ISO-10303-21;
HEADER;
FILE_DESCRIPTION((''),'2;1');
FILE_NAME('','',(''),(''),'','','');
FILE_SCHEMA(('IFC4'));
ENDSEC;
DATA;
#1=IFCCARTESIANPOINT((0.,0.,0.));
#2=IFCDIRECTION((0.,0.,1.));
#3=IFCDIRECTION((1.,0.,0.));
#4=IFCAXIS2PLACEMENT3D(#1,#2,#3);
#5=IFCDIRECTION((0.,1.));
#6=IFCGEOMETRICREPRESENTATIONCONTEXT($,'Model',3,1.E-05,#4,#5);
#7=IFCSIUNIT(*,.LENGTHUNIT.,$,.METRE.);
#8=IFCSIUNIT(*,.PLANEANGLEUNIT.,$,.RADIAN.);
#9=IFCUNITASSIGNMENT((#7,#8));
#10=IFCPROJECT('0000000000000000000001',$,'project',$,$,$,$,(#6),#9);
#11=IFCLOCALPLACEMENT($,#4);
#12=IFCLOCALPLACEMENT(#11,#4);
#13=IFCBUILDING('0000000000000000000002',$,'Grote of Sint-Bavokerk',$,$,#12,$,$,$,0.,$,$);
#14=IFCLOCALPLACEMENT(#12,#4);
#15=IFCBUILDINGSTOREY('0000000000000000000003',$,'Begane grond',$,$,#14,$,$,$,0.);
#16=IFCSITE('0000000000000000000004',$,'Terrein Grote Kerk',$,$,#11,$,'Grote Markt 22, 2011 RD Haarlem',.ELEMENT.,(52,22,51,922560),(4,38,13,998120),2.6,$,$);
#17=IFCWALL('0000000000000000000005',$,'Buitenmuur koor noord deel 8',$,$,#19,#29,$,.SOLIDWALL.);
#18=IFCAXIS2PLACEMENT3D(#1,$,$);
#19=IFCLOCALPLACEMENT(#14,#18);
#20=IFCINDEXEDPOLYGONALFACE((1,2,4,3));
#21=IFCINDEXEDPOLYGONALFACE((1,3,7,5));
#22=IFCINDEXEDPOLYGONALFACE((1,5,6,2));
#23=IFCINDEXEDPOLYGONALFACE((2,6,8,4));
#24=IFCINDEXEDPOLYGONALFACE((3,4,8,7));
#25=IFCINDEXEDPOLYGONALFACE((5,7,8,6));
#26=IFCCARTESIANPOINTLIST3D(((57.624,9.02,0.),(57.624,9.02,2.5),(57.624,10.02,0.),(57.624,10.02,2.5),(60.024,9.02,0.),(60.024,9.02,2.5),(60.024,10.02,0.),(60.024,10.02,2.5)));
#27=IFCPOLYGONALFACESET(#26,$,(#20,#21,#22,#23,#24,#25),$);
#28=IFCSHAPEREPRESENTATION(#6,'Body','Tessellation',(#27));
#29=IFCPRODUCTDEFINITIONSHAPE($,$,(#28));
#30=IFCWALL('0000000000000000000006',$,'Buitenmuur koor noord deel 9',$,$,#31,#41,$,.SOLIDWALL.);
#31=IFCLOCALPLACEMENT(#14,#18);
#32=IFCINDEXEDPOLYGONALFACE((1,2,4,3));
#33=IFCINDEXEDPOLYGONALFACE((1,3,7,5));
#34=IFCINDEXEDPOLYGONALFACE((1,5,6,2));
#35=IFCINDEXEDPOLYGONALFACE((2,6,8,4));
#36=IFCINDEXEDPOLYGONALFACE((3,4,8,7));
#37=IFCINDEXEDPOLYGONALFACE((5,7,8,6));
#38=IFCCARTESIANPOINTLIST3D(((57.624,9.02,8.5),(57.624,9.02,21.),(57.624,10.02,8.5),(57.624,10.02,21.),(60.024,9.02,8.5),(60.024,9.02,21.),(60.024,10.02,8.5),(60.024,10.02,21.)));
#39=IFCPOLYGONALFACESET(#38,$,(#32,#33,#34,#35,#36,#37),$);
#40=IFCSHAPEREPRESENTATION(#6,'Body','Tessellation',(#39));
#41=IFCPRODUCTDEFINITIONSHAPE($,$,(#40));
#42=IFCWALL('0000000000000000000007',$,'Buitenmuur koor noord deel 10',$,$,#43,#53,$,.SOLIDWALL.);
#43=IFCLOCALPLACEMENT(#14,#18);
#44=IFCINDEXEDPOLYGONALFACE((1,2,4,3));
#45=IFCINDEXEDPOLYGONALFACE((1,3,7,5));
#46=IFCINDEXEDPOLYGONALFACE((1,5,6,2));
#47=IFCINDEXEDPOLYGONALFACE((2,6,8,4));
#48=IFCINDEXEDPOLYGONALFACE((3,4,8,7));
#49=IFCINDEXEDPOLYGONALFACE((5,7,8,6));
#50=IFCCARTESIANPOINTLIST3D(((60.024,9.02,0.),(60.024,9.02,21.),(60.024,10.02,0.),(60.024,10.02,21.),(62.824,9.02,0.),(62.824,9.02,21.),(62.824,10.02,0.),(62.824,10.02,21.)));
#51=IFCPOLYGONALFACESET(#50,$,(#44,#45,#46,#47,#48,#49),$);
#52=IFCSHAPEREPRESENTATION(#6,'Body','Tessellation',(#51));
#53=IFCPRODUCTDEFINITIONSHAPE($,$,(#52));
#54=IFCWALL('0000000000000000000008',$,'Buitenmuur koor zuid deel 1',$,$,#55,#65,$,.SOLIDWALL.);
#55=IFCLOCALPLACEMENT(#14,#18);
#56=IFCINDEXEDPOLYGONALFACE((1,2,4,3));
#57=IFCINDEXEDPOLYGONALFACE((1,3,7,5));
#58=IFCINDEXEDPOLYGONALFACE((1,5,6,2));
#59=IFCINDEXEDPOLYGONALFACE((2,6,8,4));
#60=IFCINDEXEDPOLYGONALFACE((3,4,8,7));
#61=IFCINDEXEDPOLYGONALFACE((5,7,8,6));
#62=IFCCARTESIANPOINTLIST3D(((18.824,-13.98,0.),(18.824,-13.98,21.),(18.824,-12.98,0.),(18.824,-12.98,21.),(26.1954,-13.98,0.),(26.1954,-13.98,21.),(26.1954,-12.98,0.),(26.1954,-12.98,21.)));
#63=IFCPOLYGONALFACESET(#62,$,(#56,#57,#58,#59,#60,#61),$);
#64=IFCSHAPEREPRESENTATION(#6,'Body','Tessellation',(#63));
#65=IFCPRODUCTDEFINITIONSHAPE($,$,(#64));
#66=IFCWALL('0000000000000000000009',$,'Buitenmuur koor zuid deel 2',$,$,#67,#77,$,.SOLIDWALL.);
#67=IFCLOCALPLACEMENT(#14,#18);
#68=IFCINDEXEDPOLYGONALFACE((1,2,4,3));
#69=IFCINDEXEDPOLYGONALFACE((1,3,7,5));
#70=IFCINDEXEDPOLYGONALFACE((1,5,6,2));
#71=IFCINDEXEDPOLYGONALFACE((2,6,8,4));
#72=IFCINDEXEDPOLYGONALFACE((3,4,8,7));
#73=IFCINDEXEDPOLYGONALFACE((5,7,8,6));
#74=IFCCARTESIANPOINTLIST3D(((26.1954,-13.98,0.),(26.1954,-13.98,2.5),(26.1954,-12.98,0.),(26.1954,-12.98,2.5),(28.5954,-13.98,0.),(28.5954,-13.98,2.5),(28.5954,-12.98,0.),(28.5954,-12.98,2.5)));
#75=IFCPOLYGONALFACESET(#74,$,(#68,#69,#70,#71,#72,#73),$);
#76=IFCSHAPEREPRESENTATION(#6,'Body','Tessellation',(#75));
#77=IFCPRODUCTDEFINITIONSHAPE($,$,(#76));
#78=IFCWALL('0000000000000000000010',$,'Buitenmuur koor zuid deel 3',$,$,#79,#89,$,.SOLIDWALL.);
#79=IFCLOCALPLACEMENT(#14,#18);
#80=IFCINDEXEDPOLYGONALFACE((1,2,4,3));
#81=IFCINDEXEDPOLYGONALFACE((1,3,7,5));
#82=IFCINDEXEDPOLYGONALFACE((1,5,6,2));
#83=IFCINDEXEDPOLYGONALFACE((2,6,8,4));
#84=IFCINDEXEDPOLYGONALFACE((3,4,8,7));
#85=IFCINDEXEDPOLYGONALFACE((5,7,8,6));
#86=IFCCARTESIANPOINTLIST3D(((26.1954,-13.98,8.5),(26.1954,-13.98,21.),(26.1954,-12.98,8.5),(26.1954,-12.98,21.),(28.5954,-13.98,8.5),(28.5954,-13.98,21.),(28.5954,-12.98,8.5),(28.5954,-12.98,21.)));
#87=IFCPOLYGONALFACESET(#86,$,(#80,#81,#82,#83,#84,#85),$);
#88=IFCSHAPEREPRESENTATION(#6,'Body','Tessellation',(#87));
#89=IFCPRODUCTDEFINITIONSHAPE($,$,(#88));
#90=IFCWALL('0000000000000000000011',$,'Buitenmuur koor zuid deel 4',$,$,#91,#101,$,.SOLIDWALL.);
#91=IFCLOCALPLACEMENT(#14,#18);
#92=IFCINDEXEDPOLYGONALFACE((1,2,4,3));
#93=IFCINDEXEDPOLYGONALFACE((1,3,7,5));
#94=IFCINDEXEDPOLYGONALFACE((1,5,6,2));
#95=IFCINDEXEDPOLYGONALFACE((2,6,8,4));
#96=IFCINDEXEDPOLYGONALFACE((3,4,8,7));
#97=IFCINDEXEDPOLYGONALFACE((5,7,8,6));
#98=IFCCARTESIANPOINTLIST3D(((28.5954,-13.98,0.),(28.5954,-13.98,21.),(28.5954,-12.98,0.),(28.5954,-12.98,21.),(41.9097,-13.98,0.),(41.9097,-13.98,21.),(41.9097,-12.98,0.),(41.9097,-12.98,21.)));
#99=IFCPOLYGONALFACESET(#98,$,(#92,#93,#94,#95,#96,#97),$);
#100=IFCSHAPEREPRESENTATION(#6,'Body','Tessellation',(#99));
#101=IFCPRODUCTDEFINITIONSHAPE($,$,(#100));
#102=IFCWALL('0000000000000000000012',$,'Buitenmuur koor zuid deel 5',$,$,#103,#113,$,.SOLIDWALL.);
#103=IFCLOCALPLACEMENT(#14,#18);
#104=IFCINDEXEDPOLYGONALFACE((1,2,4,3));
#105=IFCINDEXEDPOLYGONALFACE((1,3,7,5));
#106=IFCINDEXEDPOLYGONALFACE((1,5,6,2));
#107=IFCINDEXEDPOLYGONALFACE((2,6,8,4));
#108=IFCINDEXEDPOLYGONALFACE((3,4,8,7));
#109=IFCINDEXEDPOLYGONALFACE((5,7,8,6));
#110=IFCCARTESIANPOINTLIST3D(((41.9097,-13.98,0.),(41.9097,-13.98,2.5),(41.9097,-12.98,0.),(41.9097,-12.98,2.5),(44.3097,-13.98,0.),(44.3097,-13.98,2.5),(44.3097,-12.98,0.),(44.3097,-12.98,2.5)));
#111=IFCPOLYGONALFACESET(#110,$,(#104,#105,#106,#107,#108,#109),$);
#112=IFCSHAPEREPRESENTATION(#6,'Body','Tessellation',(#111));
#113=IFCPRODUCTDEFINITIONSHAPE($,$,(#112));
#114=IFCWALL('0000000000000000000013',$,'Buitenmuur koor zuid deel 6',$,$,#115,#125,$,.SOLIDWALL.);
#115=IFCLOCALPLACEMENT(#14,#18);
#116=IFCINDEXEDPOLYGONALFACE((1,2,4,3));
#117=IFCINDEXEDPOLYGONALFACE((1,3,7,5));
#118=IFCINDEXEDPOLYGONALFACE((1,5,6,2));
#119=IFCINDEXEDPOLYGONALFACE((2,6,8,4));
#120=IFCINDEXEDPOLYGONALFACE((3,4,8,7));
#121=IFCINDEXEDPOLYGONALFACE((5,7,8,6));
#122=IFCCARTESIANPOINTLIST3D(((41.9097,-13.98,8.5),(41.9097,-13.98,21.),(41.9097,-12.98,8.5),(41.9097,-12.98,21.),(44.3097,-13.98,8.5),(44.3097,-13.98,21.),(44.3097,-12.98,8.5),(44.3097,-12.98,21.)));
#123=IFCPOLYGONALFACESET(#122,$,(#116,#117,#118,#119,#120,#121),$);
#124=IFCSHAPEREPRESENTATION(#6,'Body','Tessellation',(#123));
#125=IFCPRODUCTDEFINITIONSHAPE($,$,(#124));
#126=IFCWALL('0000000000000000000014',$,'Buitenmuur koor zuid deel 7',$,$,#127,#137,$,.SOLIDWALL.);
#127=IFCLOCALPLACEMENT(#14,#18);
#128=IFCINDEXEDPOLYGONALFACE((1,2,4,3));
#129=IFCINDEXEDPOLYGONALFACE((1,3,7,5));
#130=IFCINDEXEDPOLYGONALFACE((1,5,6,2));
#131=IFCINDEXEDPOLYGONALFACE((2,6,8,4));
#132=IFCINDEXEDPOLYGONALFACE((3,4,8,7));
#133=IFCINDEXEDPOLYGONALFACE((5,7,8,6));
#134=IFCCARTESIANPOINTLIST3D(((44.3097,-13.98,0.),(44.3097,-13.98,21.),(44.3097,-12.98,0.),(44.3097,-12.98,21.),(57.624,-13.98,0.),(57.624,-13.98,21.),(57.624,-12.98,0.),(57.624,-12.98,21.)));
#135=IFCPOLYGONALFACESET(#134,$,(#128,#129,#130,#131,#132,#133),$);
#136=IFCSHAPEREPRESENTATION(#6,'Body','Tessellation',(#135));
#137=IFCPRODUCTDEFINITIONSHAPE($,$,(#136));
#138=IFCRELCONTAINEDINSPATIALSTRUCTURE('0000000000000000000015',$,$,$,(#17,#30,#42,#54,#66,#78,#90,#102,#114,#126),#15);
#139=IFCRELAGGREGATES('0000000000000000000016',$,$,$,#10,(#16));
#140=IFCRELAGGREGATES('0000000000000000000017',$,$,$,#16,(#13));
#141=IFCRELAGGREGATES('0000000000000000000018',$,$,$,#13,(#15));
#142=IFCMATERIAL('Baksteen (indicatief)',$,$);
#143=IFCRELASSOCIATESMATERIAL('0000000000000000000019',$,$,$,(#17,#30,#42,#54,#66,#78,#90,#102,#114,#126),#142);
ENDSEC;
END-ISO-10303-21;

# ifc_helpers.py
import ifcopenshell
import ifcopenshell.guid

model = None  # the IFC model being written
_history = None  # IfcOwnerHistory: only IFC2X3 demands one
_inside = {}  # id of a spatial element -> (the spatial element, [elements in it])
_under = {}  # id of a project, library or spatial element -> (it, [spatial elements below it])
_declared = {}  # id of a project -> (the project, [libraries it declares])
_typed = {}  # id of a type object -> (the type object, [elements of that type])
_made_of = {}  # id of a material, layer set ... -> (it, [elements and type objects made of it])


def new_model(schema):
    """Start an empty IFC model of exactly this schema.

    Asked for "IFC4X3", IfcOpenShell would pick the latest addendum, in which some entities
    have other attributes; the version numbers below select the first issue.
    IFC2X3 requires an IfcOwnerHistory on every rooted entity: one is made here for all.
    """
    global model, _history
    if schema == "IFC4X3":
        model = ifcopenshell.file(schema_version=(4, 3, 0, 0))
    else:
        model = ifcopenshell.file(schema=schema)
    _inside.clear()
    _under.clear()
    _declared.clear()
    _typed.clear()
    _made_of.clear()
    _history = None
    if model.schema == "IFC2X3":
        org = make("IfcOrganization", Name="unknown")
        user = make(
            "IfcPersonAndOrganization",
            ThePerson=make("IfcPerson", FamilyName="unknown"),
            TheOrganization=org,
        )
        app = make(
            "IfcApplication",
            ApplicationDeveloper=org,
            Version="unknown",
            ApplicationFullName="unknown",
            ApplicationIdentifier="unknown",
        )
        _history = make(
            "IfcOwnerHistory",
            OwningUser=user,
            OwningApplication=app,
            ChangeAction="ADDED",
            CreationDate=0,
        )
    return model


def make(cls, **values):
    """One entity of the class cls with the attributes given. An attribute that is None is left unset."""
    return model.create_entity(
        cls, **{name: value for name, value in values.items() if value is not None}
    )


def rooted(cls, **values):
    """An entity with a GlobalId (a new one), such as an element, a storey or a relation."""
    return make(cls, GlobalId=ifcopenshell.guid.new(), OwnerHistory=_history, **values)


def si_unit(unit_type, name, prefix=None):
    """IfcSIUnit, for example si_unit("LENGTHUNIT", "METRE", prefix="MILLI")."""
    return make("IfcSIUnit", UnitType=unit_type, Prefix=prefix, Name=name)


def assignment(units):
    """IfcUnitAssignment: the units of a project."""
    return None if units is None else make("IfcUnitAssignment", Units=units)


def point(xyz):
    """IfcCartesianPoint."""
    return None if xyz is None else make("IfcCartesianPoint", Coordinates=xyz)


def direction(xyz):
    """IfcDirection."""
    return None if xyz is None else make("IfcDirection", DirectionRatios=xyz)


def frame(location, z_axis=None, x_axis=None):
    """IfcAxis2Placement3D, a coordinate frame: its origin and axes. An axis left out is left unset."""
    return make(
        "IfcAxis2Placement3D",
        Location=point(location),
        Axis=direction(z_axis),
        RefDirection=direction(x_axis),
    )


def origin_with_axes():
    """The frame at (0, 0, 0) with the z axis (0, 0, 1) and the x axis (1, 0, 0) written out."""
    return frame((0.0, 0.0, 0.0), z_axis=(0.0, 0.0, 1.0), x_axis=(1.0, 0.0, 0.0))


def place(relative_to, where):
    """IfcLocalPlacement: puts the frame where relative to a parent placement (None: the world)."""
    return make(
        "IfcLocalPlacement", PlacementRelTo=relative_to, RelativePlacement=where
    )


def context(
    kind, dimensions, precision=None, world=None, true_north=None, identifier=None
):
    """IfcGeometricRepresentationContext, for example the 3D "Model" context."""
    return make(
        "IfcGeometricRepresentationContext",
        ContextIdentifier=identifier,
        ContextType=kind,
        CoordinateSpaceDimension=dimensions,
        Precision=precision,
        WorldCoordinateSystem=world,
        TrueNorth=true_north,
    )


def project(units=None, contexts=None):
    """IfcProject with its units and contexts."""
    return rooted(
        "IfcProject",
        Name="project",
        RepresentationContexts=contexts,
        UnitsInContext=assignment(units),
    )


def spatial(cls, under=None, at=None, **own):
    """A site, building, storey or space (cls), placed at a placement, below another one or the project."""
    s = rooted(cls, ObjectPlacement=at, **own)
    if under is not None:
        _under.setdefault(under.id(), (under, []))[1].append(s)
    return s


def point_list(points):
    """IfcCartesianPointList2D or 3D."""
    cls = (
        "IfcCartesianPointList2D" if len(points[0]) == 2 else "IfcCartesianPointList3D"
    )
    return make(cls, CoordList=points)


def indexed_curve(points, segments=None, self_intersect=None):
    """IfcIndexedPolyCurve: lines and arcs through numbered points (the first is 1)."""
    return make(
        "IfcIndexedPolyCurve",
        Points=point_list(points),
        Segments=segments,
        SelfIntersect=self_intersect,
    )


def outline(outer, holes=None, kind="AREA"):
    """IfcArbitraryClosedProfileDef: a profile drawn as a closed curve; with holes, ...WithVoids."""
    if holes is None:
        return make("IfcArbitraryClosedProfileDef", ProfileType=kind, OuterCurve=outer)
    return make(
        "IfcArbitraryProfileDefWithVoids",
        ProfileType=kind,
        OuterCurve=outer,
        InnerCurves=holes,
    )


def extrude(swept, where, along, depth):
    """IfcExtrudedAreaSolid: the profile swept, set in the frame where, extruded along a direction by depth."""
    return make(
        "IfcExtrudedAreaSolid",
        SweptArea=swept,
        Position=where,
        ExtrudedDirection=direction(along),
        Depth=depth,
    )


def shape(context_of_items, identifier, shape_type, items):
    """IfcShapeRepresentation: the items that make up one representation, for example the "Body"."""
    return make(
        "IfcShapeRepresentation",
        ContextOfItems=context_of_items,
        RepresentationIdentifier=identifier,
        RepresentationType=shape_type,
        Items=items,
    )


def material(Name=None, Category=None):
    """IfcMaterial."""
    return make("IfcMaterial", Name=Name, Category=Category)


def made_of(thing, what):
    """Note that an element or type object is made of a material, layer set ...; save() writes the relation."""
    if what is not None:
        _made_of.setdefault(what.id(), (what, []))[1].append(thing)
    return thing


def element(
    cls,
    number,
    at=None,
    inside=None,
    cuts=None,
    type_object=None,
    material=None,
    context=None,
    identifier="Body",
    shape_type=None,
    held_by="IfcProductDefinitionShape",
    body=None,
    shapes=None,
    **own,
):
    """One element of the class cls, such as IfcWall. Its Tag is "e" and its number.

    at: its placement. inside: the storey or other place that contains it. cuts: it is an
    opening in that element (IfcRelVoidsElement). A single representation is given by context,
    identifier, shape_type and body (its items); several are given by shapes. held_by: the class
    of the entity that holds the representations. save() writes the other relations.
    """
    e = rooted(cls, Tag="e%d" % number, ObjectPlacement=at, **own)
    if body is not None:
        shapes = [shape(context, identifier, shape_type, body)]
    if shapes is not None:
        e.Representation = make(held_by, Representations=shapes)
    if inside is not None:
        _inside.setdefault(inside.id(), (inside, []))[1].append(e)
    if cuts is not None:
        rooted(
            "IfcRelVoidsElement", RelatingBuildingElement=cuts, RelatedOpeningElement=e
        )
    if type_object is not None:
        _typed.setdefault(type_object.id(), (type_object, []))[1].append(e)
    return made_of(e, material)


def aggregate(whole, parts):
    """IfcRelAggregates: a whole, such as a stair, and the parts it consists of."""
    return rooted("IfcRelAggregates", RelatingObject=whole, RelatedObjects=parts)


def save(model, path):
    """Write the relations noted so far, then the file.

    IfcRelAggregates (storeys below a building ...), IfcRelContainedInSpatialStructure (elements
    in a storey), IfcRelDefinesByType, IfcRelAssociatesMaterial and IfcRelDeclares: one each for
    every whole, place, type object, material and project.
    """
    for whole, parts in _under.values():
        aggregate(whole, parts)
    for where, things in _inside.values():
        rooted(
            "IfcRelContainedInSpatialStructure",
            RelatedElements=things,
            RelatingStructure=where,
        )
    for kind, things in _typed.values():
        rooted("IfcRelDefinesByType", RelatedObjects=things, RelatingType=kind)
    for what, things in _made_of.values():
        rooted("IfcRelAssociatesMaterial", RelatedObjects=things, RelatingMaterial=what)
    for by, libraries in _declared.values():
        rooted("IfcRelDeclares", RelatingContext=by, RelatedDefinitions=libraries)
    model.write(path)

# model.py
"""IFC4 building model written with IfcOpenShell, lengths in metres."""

from ifc_helpers import new_model, si_unit, direction, frame, origin_with_axes, place, context, project, spatial, indexed_curve, outline, extrude, material, element, save


model = new_model("IFC4")

# Units and contexts
model_context = context("Model", 3, precision=1e-05, world=origin_with_axes(), true_north=direction((0.0, 1.0)))
ifc_project = project(units=[si_unit("LENGTHUNIT", "METRE"), si_unit("PLANEANGLEUNIT", "RADIAN")], contexts=[model_context])

# Site, building, storey
site_placement = place(None, origin_with_axes())
site = spatial("IfcSite", under=ifc_project, at=site_placement, Name="Terrein Grote Kerk", LongName="Grote Markt 22, 2011 RD Haarlem", CompositionType="ELEMENT", RefLatitude=(52, 22, 51, 922560), RefLongitude=(4, 38, 13, 998120), RefElevation=2.6)
building_placement = place(site_placement, origin_with_axes())
building = spatial("IfcBuilding", under=site, at=building_placement, Name="Grote of Sint-Bavokerk", ElevationOfRefHeight=0.0)
storey_placement = place(building_placement, origin_with_axes())
storey = spatial("IfcBuildingStorey", under=building, at=storey_placement, Name="Begane grond", Elevation=0.0)

# Walls
ifc_material = material(Name="Baksteen (indicatief)")
wall_1_placement = place(storey_placement, origin_with_axes())
element("IfcWall", 1, at=wall_1_placement, inside=storey, material=ifc_material, Name="Buitenmuur koor noord deel 8", PredefinedType="SOLIDWALL", context=model_context, shape_type="SweptSolid", body=[
    extrude(outline(indexed_curve([(57.624, 9.02), (60.024, 9.02), (60.024, 10.02), (57.624, 10.02), (57.624, 9.02)])), origin_with_axes(), (0.0, 0.0, 1.0), 2.5),
])
wall_2_placement = place(storey_placement, origin_with_axes())
element("IfcWall", 2, at=wall_2_placement, inside=storey, material=ifc_material, Name="Buitenmuur koor noord deel 9", PredefinedType="SOLIDWALL", context=model_context, shape_type="SweptSolid", body=[
    extrude(outline(indexed_curve([(57.624, 9.02), (60.024, 9.02), (60.024, 10.02), (57.624, 10.02), (57.624, 9.02)])), frame((0.0, 0.0, 8.5), z_axis=(0.0, 0.0, 1.0), x_axis=(1.0, 0.0, 0.0)), (0.0, 0.0, 1.0), 12.5),
])
wall_3_placement = place(storey_placement, origin_with_axes())
element("IfcWall", 3, at=wall_3_placement, inside=storey, material=ifc_material, Name="Buitenmuur koor noord deel 10", PredefinedType="SOLIDWALL", context=model_context, shape_type="SweptSolid", body=[
    extrude(outline(indexed_curve([(60.024, 9.02), (62.824, 9.02), (62.824, 10.02), (60.024, 10.02), (60.024, 9.02)])), origin_with_axes(), (0.0, 0.0, 1.0), 21.0),
])
wall_4_placement = place(storey_placement, origin_with_axes())
element("IfcWall", 4, at=wall_4_placement, inside=storey, material=ifc_material, Name="Buitenmuur koor zuid deel 1", PredefinedType="SOLIDWALL", context=model_context, shape_type="SweptSolid", body=[
    extrude(outline(indexed_curve([(18.824, -13.98), (26.1954, -13.98), (26.1954, -12.98), (18.824, -12.98), (18.824, -13.98)])), origin_with_axes(), (0.0, 0.0, 1.0), 21.0),
])
wall_5_placement = place(storey_placement, origin_with_axes())
element("IfcWall", 5, at=wall_5_placement, inside=storey, material=ifc_material, Name="Buitenmuur koor zuid deel 2", PredefinedType="SOLIDWALL", context=model_context, shape_type="SweptSolid", body=[
    extrude(outline(indexed_curve([(26.1954, -13.98), (28.5954, -13.98), (28.5954, -12.98), (26.1954, -12.98), (26.1954, -13.98)])), origin_with_axes(), (0.0, 0.0, 1.0), 2.5),
])
wall_6_placement = place(storey_placement, origin_with_axes())
element("IfcWall", 6, at=wall_6_placement, inside=storey, material=ifc_material, Name="Buitenmuur koor zuid deel 3", PredefinedType="SOLIDWALL", context=model_context, shape_type="SweptSolid", body=[
    extrude(outline(indexed_curve([(26.1954, -13.98), (28.5954, -13.98), (28.5954, -12.98), (26.1954, -12.98), (26.1954, -13.98)])), frame((0.0, 0.0, 8.5), z_axis=(0.0, 0.0, 1.0), x_axis=(1.0, 0.0, 0.0)), (0.0, 0.0, 1.0), 12.5),
])
wall_7_placement = place(storey_placement, origin_with_axes())
element("IfcWall", 7, at=wall_7_placement, inside=storey, material=ifc_material, Name="Buitenmuur koor zuid deel 4", PredefinedType="SOLIDWALL", context=model_context, shape_type="SweptSolid", body=[
    extrude(outline(indexed_curve([(28.5954, -13.98), (41.9097, -13.98), (41.9097, -12.98), (28.5954, -12.98), (28.5954, -13.98)])), origin_with_axes(), (0.0, 0.0, 1.0), 21.0),
])
wall_8_placement = place(storey_placement, origin_with_axes())
element("IfcWall", 8, at=wall_8_placement, inside=storey, material=ifc_material, Name="Buitenmuur koor zuid deel 5", PredefinedType="SOLIDWALL", context=model_context, shape_type="SweptSolid", body=[
    extrude(outline(indexed_curve([(41.9097, -13.98), (44.3097, -13.98), (44.3097, -12.98), (41.9097, -12.98), (41.9097, -13.98)])), origin_with_axes(), (0.0, 0.0, 1.0), 2.5),
])
wall_9_placement = place(storey_placement, origin_with_axes())
element("IfcWall", 9, at=wall_9_placement, inside=storey, material=ifc_material, Name="Buitenmuur koor zuid deel 6", PredefinedType="SOLIDWALL", context=model_context, shape_type="SweptSolid", body=[
    extrude(outline(indexed_curve([(41.9097, -13.98), (44.3097, -13.98), (44.3097, -12.98), (41.9097, -12.98), (41.9097, -13.98)])), frame((0.0, 0.0, 8.5), z_axis=(0.0, 0.0, 1.0), x_axis=(1.0, 0.0, 0.0)), (0.0, 0.0, 1.0), 12.5),
])
wall_10_placement = place(storey_placement, origin_with_axes())
element("IfcWall", 10, at=wall_10_placement, inside=storey, material=ifc_material, Name="Buitenmuur koor zuid deel 7", PredefinedType="SOLIDWALL", context=model_context, shape_type="SweptSolid", body=[
    extrude(outline(indexed_curve([(44.3097, -13.98), (57.624, -13.98), (57.624, -12.98), (44.3097, -12.98), (44.3097, -13.98)])), origin_with_axes(), (0.0, 0.0, 1.0), 21.0),
])

save(model, "model.ifc")
